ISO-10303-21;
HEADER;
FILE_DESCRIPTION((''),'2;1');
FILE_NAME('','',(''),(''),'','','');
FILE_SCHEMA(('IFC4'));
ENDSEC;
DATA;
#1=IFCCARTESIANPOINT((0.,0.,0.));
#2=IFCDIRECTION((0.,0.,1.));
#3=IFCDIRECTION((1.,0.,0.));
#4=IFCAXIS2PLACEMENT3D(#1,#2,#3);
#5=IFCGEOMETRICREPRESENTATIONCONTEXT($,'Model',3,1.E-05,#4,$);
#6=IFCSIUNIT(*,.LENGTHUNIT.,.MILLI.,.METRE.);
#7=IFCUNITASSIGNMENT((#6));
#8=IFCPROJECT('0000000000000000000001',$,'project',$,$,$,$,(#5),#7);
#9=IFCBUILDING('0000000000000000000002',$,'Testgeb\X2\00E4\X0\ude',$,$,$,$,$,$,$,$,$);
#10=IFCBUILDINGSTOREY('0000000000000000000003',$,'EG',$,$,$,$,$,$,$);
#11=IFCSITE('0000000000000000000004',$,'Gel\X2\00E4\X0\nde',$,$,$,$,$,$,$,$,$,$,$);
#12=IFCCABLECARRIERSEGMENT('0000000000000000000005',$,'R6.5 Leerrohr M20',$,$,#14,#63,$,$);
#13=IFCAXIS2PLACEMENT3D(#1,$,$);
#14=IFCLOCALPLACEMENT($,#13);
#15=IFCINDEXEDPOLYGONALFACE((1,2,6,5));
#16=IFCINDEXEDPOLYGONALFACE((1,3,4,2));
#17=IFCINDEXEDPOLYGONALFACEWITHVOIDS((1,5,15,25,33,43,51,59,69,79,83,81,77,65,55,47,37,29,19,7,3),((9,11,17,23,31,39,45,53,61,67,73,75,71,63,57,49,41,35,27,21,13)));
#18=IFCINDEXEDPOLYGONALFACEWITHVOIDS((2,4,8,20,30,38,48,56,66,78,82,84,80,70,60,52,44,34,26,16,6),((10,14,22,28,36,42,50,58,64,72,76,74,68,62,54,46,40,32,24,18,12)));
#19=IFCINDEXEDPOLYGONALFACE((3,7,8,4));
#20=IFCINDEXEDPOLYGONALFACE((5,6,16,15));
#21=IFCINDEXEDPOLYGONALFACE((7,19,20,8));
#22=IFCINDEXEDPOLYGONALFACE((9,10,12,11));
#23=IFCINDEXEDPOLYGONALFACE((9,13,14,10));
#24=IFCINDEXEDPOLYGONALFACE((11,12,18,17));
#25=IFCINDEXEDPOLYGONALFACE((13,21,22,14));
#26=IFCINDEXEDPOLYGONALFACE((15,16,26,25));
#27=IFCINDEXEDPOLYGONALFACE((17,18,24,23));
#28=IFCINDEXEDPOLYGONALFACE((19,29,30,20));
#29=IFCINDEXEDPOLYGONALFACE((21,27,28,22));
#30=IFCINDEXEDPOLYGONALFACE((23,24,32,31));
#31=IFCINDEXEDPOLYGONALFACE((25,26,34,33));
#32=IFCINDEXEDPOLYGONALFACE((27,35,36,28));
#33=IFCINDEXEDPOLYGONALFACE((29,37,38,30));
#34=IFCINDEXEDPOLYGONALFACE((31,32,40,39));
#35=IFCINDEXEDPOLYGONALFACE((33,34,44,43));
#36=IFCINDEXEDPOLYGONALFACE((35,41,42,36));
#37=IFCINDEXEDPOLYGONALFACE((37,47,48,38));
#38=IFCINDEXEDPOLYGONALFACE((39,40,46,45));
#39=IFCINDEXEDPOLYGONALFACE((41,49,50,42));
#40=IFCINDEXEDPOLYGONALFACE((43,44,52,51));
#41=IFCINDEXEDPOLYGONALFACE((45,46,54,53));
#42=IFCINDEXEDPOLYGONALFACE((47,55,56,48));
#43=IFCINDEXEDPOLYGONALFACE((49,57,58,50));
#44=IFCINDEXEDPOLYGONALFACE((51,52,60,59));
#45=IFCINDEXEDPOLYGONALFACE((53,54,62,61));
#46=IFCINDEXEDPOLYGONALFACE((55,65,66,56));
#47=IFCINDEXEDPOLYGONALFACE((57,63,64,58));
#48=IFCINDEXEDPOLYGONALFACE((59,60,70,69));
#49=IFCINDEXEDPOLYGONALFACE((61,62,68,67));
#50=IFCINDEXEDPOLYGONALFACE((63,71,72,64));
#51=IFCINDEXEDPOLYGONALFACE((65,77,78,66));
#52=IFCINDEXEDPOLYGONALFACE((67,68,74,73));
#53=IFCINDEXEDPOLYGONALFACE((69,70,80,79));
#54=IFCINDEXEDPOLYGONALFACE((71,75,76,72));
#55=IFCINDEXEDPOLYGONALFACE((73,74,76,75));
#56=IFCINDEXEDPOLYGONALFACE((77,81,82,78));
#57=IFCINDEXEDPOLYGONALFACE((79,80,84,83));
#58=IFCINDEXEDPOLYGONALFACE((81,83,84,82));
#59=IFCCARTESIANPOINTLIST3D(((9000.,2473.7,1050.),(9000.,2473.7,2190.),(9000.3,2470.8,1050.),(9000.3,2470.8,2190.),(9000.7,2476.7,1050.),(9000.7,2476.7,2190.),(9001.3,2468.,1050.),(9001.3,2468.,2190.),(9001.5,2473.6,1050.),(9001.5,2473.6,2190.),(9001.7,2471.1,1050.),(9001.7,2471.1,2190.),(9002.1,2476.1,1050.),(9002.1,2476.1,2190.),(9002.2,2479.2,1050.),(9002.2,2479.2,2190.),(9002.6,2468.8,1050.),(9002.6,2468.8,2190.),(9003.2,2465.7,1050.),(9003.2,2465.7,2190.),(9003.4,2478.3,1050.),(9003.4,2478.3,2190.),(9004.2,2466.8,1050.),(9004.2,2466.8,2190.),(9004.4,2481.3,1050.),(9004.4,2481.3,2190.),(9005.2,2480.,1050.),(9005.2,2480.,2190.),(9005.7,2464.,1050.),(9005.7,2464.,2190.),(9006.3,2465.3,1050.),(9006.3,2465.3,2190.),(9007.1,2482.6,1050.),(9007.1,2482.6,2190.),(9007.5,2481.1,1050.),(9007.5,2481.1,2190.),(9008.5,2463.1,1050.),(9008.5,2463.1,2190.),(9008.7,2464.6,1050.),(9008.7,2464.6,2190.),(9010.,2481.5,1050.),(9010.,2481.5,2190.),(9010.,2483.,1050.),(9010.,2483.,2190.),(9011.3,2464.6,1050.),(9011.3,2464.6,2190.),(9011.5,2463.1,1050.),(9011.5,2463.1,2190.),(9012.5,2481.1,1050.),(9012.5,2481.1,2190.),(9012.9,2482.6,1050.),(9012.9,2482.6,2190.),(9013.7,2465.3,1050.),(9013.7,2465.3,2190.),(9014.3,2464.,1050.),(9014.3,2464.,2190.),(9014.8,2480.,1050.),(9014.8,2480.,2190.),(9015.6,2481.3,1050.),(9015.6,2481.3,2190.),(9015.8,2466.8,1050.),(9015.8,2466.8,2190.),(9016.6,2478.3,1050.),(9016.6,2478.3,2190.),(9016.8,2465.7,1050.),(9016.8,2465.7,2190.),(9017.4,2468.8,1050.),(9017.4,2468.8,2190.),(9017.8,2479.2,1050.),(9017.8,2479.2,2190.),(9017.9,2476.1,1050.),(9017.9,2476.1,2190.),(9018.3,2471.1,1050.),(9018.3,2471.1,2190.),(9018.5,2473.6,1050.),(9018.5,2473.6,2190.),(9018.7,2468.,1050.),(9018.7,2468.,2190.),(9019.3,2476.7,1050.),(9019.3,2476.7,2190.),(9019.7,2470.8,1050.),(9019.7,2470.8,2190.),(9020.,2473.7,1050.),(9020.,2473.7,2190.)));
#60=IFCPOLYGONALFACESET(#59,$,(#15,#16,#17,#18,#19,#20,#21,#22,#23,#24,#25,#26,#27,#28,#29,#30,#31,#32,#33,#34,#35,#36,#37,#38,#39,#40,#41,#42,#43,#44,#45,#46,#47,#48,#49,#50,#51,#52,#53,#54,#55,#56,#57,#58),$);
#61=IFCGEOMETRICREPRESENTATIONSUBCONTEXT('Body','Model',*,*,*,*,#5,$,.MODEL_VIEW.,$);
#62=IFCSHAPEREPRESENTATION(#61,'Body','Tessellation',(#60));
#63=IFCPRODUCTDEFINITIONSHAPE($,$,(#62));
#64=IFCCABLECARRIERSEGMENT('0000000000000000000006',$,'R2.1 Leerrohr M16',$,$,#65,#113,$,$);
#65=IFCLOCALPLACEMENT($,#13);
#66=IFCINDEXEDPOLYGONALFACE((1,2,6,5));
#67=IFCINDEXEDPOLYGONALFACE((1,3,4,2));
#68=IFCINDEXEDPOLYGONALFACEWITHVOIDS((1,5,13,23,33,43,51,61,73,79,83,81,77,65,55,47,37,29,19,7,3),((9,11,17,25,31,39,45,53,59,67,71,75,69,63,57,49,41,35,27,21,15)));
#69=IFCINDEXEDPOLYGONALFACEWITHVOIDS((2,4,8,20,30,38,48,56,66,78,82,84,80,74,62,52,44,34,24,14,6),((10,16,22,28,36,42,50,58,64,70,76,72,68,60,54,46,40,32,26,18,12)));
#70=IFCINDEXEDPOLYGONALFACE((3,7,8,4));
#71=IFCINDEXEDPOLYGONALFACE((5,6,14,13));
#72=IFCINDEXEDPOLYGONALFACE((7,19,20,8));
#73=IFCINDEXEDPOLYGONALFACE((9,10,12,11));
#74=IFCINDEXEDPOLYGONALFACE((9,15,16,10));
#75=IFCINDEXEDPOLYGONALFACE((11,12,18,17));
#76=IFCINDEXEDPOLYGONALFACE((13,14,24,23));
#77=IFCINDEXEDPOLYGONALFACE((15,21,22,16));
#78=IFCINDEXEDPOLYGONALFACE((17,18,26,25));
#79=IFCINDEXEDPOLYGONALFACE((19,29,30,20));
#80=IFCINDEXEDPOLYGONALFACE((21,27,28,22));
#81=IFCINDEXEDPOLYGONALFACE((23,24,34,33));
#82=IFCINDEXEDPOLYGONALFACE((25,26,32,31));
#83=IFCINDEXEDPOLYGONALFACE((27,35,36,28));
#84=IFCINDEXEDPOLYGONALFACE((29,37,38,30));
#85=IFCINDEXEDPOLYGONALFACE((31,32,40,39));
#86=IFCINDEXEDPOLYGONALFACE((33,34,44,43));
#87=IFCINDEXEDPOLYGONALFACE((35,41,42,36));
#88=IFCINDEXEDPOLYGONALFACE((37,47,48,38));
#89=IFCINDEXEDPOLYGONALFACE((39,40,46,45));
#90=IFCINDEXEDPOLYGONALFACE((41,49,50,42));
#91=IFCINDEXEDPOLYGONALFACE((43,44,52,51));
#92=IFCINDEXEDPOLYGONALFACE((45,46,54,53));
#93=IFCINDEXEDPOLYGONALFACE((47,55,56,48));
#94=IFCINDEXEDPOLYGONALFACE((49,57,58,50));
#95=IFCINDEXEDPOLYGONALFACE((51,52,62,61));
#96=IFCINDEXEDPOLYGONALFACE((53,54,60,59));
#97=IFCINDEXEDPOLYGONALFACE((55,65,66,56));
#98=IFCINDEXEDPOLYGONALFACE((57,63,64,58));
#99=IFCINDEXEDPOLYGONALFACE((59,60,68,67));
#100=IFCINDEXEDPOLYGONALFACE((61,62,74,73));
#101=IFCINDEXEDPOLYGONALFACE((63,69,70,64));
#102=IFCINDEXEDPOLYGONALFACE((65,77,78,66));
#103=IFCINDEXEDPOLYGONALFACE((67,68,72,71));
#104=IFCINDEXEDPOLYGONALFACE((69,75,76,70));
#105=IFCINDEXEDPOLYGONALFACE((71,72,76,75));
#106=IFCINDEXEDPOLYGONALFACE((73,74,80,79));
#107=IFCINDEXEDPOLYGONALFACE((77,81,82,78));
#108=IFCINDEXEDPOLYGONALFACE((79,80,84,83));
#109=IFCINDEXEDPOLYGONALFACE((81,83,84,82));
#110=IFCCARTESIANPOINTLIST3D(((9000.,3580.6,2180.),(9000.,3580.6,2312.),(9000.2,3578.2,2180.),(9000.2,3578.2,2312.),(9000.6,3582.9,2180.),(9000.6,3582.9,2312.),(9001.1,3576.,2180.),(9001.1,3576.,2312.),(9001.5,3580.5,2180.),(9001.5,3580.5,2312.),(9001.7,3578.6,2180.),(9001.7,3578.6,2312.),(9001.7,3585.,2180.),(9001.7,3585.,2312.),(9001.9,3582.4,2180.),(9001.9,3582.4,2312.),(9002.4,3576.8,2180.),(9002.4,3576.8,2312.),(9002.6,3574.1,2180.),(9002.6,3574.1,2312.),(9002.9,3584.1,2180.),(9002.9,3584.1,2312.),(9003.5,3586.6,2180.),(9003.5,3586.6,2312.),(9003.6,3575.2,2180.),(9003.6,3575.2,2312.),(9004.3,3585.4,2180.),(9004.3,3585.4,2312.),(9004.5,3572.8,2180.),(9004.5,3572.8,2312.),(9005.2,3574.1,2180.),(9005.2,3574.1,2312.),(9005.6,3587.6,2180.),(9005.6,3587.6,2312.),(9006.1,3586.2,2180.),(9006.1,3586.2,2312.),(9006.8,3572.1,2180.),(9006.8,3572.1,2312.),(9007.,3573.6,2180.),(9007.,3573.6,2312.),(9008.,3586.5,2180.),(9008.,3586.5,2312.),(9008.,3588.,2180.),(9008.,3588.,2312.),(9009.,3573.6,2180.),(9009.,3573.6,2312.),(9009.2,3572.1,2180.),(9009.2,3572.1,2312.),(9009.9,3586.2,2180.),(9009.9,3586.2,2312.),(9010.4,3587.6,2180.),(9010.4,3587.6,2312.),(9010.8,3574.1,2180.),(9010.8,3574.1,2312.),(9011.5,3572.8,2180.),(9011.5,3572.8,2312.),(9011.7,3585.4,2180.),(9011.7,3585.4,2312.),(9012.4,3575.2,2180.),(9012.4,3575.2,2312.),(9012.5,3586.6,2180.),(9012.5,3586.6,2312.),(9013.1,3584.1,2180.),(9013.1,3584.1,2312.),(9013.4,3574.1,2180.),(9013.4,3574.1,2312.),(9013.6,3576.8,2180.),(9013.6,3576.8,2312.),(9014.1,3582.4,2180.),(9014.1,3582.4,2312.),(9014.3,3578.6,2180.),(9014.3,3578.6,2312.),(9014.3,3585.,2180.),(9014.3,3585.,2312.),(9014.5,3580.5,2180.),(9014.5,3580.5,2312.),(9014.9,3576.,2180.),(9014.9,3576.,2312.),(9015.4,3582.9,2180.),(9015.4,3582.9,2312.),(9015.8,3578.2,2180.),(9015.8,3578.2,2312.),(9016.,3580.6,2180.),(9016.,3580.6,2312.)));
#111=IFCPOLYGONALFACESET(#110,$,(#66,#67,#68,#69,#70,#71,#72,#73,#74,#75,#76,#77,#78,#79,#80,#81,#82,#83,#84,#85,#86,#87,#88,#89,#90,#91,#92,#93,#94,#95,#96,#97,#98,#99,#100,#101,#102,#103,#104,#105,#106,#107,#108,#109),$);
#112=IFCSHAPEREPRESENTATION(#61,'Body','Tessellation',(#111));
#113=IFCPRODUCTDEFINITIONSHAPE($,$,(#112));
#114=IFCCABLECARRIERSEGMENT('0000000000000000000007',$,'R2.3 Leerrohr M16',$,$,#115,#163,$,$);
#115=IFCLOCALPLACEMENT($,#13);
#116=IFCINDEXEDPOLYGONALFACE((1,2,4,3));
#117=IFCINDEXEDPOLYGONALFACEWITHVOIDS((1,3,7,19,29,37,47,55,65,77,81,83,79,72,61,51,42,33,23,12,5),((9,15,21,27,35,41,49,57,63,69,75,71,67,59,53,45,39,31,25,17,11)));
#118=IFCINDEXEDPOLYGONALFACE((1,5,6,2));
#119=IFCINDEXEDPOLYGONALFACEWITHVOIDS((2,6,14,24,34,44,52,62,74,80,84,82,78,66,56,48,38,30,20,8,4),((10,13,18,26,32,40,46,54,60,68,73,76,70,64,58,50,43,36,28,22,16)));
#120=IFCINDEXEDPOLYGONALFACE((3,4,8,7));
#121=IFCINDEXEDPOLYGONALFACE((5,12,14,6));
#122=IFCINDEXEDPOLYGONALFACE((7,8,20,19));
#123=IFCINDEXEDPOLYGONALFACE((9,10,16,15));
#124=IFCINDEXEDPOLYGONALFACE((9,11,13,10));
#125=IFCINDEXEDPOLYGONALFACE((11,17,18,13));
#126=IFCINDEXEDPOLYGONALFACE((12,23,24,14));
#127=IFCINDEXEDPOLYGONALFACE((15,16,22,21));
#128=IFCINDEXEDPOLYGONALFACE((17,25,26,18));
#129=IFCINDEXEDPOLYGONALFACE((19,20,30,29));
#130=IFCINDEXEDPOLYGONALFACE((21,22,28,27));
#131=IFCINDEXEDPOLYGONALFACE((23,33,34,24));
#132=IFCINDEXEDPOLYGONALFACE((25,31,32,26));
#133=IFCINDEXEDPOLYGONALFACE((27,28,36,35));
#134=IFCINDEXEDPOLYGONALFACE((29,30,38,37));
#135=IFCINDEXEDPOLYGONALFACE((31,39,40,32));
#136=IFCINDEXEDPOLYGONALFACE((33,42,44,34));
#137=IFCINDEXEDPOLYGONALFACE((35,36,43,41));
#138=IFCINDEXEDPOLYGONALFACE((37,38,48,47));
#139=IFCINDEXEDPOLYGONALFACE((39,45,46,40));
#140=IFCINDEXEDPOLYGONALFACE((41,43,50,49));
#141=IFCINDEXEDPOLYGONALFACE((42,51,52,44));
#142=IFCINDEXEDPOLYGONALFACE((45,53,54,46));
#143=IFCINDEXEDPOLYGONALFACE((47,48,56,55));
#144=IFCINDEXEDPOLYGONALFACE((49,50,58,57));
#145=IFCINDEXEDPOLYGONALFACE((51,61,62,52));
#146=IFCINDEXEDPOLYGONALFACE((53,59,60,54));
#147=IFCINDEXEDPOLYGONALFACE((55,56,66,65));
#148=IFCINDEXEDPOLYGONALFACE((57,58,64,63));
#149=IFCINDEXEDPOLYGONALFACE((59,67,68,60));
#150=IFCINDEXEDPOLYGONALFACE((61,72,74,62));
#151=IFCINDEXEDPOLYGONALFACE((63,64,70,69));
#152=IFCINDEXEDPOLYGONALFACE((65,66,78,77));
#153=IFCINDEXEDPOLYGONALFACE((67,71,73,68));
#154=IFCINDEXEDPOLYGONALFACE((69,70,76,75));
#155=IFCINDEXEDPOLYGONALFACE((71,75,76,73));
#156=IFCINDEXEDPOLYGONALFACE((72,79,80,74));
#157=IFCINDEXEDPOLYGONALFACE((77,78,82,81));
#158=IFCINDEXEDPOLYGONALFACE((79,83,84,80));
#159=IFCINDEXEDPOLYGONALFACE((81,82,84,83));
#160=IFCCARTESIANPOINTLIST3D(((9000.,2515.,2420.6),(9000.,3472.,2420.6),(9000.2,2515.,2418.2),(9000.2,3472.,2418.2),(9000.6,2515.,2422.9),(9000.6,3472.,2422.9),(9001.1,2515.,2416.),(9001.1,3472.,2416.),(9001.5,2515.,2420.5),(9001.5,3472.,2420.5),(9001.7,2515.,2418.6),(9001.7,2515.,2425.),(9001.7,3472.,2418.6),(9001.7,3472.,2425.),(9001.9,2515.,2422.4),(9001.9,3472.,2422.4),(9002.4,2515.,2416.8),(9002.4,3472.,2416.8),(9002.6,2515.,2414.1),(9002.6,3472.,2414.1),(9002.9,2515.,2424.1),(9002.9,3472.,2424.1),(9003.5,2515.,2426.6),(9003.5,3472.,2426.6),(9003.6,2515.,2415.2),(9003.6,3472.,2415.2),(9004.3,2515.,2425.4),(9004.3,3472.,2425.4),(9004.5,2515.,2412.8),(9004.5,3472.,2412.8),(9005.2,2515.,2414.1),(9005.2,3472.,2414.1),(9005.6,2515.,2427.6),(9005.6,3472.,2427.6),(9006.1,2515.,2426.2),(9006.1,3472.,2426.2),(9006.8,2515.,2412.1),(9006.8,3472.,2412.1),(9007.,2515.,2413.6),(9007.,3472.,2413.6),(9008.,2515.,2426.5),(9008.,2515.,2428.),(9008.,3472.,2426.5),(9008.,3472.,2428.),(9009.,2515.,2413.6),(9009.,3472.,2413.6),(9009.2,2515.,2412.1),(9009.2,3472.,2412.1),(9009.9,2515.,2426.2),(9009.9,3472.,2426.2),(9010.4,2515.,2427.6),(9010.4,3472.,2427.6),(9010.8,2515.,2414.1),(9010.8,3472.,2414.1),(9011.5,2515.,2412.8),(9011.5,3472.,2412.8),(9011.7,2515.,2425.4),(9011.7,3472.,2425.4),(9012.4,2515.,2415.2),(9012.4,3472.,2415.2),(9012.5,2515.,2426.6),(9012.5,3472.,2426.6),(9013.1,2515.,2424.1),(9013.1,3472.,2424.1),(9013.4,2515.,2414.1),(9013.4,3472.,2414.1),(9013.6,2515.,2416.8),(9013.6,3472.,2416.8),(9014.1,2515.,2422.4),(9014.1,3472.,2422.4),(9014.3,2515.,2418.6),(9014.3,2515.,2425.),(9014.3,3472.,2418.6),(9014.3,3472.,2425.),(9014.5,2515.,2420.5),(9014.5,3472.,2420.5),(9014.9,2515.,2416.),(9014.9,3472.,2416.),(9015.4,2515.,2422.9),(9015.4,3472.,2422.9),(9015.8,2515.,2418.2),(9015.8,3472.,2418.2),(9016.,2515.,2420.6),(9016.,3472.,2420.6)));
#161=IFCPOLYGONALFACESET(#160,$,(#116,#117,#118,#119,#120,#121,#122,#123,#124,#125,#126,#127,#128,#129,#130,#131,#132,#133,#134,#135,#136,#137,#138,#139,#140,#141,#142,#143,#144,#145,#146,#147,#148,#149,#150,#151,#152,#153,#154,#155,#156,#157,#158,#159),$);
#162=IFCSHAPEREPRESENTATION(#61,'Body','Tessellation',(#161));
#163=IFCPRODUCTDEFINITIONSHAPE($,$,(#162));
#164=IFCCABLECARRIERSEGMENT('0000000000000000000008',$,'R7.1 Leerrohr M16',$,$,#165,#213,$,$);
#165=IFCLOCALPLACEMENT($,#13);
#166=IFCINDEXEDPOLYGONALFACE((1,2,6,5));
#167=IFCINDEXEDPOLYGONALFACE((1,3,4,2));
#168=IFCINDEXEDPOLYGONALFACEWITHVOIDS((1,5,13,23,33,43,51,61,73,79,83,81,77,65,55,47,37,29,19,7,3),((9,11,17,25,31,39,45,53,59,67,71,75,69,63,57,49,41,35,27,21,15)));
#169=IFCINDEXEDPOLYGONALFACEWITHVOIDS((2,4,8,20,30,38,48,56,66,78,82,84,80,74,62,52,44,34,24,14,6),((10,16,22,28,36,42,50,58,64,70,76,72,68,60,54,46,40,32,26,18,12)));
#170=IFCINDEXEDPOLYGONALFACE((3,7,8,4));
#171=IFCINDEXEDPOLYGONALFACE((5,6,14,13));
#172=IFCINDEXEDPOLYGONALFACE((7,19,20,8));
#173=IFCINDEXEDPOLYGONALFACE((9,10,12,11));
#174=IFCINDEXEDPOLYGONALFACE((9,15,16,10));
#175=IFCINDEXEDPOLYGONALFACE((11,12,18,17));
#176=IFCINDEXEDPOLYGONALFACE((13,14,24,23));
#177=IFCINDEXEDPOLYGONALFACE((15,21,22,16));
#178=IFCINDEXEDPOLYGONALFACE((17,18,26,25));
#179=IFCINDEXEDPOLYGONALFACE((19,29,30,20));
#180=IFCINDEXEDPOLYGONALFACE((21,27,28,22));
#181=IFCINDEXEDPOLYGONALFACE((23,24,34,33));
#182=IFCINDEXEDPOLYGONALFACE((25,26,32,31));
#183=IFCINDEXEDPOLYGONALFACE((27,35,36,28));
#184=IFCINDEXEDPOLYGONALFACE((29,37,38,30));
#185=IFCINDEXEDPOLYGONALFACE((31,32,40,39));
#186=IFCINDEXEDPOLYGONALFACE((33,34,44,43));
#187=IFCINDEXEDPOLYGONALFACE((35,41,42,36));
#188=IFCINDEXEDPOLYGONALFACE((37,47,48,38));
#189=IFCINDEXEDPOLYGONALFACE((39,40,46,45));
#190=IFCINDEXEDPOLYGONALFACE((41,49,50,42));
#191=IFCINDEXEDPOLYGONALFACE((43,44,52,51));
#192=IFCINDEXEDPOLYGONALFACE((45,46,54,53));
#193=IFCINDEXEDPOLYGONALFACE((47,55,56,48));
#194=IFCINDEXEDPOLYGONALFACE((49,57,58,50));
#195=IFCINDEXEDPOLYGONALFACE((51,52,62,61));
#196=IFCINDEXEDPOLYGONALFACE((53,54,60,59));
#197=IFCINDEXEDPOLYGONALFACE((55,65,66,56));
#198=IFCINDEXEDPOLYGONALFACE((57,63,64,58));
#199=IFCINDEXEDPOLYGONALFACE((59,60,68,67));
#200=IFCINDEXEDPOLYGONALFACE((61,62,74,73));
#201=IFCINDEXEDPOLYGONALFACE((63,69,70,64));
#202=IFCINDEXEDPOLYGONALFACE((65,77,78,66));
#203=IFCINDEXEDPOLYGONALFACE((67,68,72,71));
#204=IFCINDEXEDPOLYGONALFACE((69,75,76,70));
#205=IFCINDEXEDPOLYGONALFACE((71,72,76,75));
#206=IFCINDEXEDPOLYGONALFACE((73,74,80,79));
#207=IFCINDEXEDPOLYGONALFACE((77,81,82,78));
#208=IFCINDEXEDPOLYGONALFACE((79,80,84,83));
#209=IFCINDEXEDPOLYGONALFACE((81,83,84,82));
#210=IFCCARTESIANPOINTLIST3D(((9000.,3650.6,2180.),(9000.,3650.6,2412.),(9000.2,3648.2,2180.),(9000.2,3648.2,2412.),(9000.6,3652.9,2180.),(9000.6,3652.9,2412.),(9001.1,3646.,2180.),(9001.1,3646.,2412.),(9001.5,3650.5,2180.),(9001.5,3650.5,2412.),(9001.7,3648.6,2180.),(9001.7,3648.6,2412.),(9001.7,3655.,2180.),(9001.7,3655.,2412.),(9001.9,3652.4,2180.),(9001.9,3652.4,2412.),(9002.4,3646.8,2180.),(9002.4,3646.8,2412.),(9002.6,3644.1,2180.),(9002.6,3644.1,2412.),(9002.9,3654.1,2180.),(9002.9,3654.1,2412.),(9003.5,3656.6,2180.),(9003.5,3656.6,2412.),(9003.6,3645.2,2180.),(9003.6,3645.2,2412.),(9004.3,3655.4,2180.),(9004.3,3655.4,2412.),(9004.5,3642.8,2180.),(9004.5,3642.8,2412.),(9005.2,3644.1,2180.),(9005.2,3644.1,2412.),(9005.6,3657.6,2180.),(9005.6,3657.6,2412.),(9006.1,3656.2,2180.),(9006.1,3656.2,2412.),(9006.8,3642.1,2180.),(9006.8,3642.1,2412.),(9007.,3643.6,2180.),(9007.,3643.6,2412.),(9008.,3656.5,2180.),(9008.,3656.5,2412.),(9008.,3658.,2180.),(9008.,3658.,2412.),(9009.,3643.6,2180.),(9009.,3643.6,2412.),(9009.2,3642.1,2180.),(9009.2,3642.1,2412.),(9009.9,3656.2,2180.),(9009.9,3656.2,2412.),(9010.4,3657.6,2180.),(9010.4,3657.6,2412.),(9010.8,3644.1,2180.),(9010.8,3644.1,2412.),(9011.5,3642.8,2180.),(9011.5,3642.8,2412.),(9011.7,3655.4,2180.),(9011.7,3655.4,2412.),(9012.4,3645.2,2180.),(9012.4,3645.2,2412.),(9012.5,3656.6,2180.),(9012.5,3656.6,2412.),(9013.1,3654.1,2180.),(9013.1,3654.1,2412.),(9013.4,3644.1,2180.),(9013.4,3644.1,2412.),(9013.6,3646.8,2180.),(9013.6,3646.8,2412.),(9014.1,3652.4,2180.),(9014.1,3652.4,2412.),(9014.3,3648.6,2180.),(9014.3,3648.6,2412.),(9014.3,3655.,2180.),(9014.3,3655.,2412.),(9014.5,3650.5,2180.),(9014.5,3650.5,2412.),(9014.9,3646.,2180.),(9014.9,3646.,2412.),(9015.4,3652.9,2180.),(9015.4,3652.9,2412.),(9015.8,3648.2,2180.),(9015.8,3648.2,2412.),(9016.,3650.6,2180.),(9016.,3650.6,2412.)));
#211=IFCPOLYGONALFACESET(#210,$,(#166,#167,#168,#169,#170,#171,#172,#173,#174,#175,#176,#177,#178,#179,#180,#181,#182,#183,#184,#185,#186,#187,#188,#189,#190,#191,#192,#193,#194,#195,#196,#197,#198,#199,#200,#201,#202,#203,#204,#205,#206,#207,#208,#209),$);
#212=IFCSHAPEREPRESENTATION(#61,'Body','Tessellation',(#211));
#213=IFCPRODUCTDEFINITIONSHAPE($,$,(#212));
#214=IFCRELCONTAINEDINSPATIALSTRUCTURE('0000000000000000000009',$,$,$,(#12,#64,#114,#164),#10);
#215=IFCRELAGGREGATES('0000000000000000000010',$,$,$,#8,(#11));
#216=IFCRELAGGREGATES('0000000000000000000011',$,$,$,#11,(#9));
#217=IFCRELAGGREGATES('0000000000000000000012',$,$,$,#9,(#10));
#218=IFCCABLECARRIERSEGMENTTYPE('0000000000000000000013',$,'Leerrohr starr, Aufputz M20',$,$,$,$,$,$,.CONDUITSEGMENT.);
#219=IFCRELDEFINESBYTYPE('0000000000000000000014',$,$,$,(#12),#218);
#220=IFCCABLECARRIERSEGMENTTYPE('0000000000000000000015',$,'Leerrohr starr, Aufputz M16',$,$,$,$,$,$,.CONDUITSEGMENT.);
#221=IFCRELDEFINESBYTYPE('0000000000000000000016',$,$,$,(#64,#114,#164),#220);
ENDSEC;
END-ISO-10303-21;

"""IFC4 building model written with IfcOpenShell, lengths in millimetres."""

from ifc_helpers import new_model, si_unit, frame, origin_with_axes, place, context, subcontext, project, spatial, hollow_circle, extrude, type_object, element, save


model = new_model("IFC4")

# Units and contexts
model_context = context("Model", 3, precision=1e-05, world=origin_with_axes())
body_context = subcontext(model_context, "Body", "Model", "MODEL_VIEW")
ifc_project = project(units=[si_unit("LENGTHUNIT", "METRE", prefix="MILLI")], contexts=[model_context])

# Site, building, storey
site = spatial("IfcSite", under=ifc_project, Name="Gelände")
building = spatial("IfcBuilding", under=site, Name="Testgebäude")
storey = spatial("IfcBuildingStorey", under=building, Name="EG")

# Cable carrier segment
cable_carrier_segment_type_1 = type_object("IfcCableCarrierSegmentType", Name="Leerrohr starr, Aufputz M20", PredefinedType="CONDUITSEGMENT")
cable_carrier_segment_1_placement = place(None, frame((9010.0, 2473.0, 2190.0), z_axis=(0.0, 0.0, -1.0), x_axis=(0.0, 1.0, 0.0)))
element("IfcCableCarrierSegment", 1, at=cable_carrier_segment_1_placement, inside=storey, type_object=cable_carrier_segment_type_1, Name="R6.5 Leerrohr M20", context=body_context, shape_type="SweptSolid", body=[
    extrude(hollow_circle(Radius=10.0, WallThickness=1.5), None, (0.0, 0.0, 1.0), 1140.0),
])

# Cable carrier segments
cable_carrier_segment_type_2 = type_object("IfcCableCarrierSegmentType", Name="Leerrohr starr, Aufputz M16", PredefinedType="CONDUITSEGMENT")
cable_carrier_segment_2_placement = place(None, frame((9008.0, 3580.0, 2180.0), z_axis=(0.0, 0.0, 1.0), x_axis=(0.0, 1.0, 0.0)))
element("IfcCableCarrierSegment", 2, at=cable_carrier_segment_2_placement, inside=storey, type_object=cable_carrier_segment_type_2, Name="R2.1 Leerrohr M16", context=body_context, shape_type="SweptSolid", body=[
    extrude(hollow_circle(Radius=8.0, WallThickness=1.5), None, (0.0, 0.0, 1.0), 132.0),
])
cable_carrier_segment_3_placement = place(None, frame((9008.0, 3472.0, 2420.0), z_axis=(0.0, -1.0, 0.0), x_axis=(0.0, 0.0, 1.0)))
element("IfcCableCarrierSegment", 3, at=cable_carrier_segment_3_placement, inside=storey, type_object=cable_carrier_segment_type_2, Name="R2.3 Leerrohr M16", context=body_context, shape_type="SweptSolid", body=[
    extrude(hollow_circle(Radius=8.0, WallThickness=1.5), None, (0.0, 0.0, 1.0), 957.0),
])
cable_carrier_segment_4_placement = place(None, frame((9008.0, 3650.0, 2180.0), z_axis=(0.0, 0.0, 1.0), x_axis=(0.0, 1.0, 0.0)))
element("IfcCableCarrierSegment", 4, at=cable_carrier_segment_4_placement, inside=storey, type_object=cable_carrier_segment_type_2, Name="R7.1 Leerrohr M16", context=body_context, shape_type="SweptSolid", body=[
    extrude(hollow_circle(Radius=8.0, WallThickness=1.5), None, (0.0, 0.0, 1.0), 232.0),
])

save(model, "model.ifc")
